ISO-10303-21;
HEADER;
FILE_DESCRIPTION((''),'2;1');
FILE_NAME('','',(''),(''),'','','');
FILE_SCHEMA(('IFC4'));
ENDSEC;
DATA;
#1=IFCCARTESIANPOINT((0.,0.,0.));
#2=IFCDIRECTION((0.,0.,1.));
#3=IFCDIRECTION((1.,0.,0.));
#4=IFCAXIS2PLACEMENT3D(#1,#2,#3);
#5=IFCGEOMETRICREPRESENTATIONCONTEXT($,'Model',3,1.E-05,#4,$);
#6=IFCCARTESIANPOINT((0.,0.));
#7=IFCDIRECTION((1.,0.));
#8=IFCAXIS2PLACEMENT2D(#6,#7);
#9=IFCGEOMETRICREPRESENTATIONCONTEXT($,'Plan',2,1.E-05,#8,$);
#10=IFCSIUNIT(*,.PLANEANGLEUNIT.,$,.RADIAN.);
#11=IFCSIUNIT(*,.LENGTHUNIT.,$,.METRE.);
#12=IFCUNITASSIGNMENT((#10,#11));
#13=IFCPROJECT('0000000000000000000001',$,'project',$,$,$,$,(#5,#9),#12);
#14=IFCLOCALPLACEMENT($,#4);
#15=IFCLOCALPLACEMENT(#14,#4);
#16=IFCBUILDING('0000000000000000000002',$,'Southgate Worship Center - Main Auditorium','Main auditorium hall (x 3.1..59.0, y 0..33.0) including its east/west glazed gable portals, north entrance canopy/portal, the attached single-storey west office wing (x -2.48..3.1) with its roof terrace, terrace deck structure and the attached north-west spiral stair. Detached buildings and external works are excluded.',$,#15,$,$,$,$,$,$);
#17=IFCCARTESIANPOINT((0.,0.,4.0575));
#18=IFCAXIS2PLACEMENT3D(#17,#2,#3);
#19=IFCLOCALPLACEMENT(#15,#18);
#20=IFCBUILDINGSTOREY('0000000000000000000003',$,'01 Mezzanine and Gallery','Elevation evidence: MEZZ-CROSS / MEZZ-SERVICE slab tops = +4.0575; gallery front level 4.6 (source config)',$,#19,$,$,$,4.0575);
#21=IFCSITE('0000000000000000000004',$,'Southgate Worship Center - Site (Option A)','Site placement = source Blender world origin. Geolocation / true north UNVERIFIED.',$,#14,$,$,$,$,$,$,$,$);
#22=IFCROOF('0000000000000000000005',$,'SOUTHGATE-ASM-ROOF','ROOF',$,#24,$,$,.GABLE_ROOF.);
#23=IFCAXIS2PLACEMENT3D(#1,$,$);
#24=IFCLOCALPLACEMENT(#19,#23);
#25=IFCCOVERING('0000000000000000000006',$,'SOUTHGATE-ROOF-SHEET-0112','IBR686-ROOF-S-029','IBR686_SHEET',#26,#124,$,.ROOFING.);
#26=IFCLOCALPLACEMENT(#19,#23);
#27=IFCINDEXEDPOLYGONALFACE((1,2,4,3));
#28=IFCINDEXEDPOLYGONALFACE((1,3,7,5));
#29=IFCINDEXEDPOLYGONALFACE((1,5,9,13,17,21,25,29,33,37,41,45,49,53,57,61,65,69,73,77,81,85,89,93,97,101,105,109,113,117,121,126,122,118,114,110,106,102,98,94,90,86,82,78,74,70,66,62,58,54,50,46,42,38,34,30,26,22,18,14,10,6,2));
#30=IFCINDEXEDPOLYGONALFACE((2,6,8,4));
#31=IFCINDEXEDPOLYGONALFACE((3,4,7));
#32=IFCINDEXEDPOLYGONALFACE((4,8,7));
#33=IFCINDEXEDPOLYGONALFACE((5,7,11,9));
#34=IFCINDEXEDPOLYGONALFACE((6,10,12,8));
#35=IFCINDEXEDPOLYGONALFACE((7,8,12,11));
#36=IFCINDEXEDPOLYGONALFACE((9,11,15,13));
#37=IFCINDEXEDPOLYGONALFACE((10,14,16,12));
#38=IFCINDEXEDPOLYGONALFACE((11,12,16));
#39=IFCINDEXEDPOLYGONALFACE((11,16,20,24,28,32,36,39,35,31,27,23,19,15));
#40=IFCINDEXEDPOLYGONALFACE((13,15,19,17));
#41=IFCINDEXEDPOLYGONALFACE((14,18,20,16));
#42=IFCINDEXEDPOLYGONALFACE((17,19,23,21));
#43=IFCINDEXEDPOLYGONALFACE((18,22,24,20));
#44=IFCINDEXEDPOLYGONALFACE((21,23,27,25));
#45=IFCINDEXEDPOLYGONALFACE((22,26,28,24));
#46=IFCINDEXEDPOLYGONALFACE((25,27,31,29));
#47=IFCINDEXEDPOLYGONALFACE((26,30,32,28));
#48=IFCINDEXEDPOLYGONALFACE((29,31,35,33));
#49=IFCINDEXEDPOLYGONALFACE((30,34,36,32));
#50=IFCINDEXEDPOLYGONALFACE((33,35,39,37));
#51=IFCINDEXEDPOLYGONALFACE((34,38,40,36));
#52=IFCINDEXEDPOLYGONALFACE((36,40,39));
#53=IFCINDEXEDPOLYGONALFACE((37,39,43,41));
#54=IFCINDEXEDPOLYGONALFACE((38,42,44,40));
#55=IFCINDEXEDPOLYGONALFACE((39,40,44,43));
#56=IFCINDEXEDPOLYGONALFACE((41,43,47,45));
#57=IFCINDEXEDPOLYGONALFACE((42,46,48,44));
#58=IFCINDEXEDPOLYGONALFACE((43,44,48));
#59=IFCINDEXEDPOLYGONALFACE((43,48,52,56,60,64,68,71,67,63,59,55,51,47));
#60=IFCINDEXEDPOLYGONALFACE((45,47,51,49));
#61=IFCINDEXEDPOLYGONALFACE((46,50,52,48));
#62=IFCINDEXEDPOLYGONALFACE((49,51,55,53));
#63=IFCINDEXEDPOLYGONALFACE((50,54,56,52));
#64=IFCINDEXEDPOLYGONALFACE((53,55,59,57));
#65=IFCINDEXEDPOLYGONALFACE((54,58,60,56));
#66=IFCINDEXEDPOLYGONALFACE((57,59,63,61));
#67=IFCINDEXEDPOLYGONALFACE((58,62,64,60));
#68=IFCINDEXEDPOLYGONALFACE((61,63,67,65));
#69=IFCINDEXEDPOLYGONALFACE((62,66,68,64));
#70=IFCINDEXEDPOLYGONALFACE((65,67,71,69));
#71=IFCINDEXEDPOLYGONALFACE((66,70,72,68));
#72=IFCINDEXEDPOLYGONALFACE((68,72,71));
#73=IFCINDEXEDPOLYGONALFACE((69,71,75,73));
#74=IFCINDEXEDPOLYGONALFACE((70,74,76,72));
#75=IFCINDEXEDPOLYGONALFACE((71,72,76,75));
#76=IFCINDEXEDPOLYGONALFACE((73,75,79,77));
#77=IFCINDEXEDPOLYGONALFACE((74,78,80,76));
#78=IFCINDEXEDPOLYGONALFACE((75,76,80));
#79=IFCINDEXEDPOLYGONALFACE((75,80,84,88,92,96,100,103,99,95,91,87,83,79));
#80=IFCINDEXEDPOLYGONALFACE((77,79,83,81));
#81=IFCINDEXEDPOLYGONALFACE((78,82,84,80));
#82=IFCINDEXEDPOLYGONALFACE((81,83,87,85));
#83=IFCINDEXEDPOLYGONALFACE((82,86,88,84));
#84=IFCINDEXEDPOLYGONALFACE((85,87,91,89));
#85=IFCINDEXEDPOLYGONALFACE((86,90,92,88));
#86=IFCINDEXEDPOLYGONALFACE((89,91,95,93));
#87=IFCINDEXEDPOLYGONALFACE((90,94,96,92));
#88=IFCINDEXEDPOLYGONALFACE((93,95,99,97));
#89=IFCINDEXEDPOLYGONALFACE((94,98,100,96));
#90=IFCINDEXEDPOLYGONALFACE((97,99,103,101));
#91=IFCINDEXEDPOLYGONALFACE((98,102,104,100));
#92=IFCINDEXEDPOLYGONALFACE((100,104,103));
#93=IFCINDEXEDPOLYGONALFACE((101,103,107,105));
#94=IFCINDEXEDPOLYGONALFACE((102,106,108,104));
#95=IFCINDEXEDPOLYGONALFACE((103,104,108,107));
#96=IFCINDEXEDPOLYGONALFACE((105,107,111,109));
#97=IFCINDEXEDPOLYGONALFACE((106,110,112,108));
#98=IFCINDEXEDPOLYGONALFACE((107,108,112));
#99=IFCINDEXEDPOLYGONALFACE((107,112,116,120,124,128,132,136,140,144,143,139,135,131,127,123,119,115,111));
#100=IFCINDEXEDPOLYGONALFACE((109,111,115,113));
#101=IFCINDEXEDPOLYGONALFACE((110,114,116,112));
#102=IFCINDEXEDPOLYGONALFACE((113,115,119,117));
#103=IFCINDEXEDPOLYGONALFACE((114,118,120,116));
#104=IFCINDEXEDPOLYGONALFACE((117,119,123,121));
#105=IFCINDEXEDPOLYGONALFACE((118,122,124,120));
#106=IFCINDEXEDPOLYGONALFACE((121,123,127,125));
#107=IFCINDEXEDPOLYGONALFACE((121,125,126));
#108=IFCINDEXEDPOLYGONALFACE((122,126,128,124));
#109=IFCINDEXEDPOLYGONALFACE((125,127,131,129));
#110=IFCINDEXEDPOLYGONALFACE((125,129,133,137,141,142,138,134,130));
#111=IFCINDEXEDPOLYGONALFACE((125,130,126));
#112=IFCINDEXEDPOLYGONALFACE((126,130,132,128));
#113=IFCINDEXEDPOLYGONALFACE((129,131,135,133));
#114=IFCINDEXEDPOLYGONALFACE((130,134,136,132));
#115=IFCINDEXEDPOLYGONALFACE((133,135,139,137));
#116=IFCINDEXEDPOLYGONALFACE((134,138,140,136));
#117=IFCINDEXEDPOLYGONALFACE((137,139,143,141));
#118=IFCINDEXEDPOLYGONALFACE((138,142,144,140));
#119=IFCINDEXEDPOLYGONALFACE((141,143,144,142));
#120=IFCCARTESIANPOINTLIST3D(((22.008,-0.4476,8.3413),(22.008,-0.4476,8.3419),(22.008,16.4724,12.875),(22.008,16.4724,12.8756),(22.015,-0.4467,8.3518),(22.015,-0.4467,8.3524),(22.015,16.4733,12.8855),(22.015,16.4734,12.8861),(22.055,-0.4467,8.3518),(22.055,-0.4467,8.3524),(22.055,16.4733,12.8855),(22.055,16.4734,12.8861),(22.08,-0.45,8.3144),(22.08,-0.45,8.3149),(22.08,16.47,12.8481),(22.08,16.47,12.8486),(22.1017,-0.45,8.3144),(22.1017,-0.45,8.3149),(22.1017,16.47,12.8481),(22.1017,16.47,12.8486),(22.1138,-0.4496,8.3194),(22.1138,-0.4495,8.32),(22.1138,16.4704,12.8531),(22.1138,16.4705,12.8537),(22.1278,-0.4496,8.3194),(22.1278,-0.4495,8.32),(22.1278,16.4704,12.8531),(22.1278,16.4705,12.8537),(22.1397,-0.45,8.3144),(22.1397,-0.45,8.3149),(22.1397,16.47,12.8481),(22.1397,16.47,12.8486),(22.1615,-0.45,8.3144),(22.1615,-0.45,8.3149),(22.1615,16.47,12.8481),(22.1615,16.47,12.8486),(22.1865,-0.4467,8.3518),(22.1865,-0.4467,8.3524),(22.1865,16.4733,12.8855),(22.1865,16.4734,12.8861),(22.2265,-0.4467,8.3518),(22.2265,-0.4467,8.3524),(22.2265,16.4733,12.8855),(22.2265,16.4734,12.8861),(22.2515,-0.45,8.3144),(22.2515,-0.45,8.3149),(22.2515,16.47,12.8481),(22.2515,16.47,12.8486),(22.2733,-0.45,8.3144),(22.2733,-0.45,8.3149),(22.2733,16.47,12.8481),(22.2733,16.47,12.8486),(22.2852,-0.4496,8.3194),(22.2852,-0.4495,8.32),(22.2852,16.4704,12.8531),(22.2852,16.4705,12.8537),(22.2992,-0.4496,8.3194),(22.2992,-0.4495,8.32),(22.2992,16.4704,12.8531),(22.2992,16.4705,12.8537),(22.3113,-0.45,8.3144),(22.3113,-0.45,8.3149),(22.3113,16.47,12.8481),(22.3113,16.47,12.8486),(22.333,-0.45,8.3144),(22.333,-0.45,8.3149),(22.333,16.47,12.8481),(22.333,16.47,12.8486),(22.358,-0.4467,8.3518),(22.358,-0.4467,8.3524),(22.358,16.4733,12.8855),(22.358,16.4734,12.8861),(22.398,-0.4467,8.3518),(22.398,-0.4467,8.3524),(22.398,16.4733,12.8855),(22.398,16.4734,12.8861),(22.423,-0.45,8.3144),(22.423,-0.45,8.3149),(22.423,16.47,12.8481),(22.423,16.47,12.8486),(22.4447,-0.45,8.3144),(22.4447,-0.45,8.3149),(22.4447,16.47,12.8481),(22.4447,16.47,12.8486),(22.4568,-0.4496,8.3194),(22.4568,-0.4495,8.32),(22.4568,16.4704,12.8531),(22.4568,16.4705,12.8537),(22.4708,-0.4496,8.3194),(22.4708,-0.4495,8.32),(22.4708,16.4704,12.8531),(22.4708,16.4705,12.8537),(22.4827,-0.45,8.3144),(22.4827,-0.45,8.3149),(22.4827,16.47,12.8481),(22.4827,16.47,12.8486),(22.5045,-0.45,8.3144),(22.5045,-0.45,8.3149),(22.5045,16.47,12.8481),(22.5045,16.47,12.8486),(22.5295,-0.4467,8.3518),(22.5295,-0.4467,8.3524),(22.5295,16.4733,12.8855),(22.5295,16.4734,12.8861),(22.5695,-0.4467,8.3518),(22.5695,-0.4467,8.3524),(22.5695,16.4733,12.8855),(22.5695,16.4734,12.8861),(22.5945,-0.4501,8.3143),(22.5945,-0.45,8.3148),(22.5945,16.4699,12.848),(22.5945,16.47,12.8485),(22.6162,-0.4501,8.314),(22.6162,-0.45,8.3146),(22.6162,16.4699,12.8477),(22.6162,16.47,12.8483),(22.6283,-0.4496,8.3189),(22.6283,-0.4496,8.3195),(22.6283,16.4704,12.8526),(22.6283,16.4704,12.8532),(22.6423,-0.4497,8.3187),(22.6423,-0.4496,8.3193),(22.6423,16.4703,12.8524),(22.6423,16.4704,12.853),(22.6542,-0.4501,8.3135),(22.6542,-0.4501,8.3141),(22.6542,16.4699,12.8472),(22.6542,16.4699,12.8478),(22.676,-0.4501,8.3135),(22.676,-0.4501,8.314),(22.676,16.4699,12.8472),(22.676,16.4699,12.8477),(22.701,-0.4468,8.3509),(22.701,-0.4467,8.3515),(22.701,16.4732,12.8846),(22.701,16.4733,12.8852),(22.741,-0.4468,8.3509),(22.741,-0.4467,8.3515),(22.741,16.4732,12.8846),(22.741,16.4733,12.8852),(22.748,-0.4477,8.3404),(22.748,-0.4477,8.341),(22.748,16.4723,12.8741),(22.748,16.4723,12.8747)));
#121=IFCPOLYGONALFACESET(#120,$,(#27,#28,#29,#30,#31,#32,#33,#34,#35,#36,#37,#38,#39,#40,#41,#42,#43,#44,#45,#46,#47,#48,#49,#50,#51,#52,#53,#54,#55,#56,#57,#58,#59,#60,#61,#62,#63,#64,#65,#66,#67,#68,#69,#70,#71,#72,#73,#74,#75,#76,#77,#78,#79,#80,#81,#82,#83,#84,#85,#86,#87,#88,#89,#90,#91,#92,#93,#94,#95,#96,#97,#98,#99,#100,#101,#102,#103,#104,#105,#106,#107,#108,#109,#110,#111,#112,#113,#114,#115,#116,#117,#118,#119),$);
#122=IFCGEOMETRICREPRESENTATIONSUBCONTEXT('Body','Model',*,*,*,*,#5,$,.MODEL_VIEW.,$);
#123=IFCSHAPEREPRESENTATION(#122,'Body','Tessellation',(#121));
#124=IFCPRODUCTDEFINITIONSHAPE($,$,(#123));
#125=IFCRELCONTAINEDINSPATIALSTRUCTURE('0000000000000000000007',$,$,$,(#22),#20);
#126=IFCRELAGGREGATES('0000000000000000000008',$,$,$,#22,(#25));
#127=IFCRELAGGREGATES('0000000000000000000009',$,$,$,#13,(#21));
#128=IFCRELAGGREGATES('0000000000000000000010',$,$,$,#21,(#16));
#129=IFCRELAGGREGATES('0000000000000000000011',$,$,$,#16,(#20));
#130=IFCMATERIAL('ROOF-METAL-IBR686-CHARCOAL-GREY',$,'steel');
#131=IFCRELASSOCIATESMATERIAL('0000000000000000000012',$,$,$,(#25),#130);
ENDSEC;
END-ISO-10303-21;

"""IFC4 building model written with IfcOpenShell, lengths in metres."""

from ifc_helpers import new_model, si_unit, frame, origin_with_axes, origin_2d_with_axis, place, context, subcontext, project, spatial, indexed_curve, outline, extrude, clip, halfspace, material, element, aggregate, save


model = new_model("IFC4")

# Units and contexts
model_context = context("Model", 3, precision=1e-05, world=origin_with_axes())
plan_context = context("Plan", 2, precision=1e-05, world=origin_2d_with_axis())
body_context = subcontext(model_context, "Body", "Model", "MODEL_VIEW")
ifc_project = project(units=[si_unit("PLANEANGLEUNIT", "RADIAN"), si_unit("LENGTHUNIT", "METRE")], contexts=[model_context, plan_context])

# Site, building, storey
site_placement = place(None, origin_with_axes())
site = spatial("IfcSite", under=ifc_project, at=site_placement, Name="Southgate Worship Center - Site (Option A)", Description="Site placement = source Blender world origin. Geolocation / true north UNVERIFIED.")
building_placement = place(site_placement, origin_with_axes())
building = spatial("IfcBuilding", under=site, at=building_placement, Name="Southgate Worship Center - Main Auditorium", Description="Main auditorium hall (x 3.1..59.0, y 0..33.0) including its east/west glazed gable portals, north entrance canopy/portal, the attached single-storey west office wing (x -2.48..3.1) with its roof terrace, terrace deck structure and the attached north-west spiral stair. Detached buildings and external works are excluded.")
storey_placement = place(building_placement, frame((0.0, 0.0, 4.0575), z_axis=(0.0, 0.0, 1.0), x_axis=(1.0, 0.0, 0.0)))
storey = spatial("IfcBuildingStorey", under=building, at=storey_placement, Name="01 Mezzanine and Gallery", Description="Elevation evidence: MEZZ-CROSS / MEZZ-SERVICE slab tops = +4.0575; gallery front level 4.6 (source config)", Elevation=4.0575)

# Roof, covering
roof_placement = place(storey_placement, origin_with_axes())
roof = element("IfcRoof", 1, at=roof_placement, inside=storey, Name="SOUTHGATE-ASM-ROOF", Description="ROOF", PredefinedType="GABLE_ROOF")
ifc_material_1 = material(Name="ROOF-METAL-IBR686-CHARCOAL-GREY", Category="steel")
covering_1_placement = place(roof_placement, frame((22.008, -0.4501, 8.3135), z_axis=(0.0, 0.0, 1.0), x_axis=(1.0, 0.0, 0.0)))
covering_1 = element("IfcCovering", 2, at=covering_1_placement, material=ifc_material_1, Name="SOUTHGATE-ROOF-SHEET-0112", Description="IBR686-ROOF-S-029", ObjectType="IBR686_SHEET", PredefinedType="ROOFING", context=body_context, shape_type="Clipping", body=[
    clip(clip(extrude(outline(indexed_curve([(0.0, 0.0), (0.025, 0.0353), (0.065, 0.0353), (0.072, 0.0254), (0.072, 0.0259), (0.065, 0.0358), (0.025, 0.0358), (0.0, 0.0005), (-0.0217, 0.0005), (-0.0338, 0.0053), (-0.0478, 0.0053), (-0.0597, 0.0005), (-0.0815, 0.0005), (-0.1065, 0.0358), (-0.1465, 0.0358), (-0.1715, 0.0005), (-0.1933, 0.0005), (-0.2052, 0.0053), (-0.2192, 0.0053), (-0.2313, 0.0005), (-0.253, 0.0005), (-0.278, 0.0358), (-0.318, 0.0358), (-0.343, 0.0005), (-0.3647, 0.0005), (-0.3768, 0.0053), (-0.3908, 0.0053), (-0.4028, 0.0005), (-0.4245, 0.0005), (-0.4495, 0.0358), (-0.4895, 0.0358), (-0.5145, 0.0004), (-0.5362, 0.0002), (-0.5483, 0.0048), (-0.5623, 0.0046), (-0.5742, -0.0003), (-0.596, -0.0004), (-0.621, 0.0349), (-0.661, 0.0349), (-0.668, 0.0251), (-0.668, 0.0246), (-0.661, 0.0344), (-0.621, 0.0344), (-0.596, -0.0009), (-0.5742, -0.0008), (-0.5623, 0.0041), (-0.5483, 0.0043), (-0.5362, -0.0003), (-0.5145, -0.0001), (-0.4895, 0.0353), (-0.4495, 0.0353), (-0.4245, 0.0), (-0.4028, 0.0), (-0.3908, 0.0048), (-0.3768, 0.0048), (-0.3647, 0.0), (-0.343, 0.0), (-0.318, 0.0353), (-0.278, 0.0353), (-0.253, 0.0), (-0.2313, 0.0), (-0.2192, 0.0048), (-0.2052, 0.0048), (-0.1933, 0.0), (-0.1715, 0.0), (-0.1465, 0.0353), (-0.1065, 0.0353), (-0.0815, 0.0), (-0.0597, 0.0), (-0.0478, 0.0048), (-0.0338, 0.0048), (-0.0217, 0.0), (0.0, 0.0)], self_intersect=False)), frame((0.072, -0.0003, 0.0008), z_axis=(0.0, 0.965926, 0.258819), x_axis=(-1.0, 0.0, 0.0)), (0.0, 0.0, 1.0), 17.5303), halfspace(frame((0.37, 0.0012, 0.014), z_axis=(0.0, -0.996022, 0.089113), x_axis=(1.0, 0.0, 0.0)), False)), halfspace(frame((0.37, 16.9212, 4.5477), z_axis=(0.0, 0.996021, -0.089119), x_axis=(-1.0, 0.0, 0.0)), False)),
])
aggregate(roof, [covering_1])

save(model, "model.ifc")
